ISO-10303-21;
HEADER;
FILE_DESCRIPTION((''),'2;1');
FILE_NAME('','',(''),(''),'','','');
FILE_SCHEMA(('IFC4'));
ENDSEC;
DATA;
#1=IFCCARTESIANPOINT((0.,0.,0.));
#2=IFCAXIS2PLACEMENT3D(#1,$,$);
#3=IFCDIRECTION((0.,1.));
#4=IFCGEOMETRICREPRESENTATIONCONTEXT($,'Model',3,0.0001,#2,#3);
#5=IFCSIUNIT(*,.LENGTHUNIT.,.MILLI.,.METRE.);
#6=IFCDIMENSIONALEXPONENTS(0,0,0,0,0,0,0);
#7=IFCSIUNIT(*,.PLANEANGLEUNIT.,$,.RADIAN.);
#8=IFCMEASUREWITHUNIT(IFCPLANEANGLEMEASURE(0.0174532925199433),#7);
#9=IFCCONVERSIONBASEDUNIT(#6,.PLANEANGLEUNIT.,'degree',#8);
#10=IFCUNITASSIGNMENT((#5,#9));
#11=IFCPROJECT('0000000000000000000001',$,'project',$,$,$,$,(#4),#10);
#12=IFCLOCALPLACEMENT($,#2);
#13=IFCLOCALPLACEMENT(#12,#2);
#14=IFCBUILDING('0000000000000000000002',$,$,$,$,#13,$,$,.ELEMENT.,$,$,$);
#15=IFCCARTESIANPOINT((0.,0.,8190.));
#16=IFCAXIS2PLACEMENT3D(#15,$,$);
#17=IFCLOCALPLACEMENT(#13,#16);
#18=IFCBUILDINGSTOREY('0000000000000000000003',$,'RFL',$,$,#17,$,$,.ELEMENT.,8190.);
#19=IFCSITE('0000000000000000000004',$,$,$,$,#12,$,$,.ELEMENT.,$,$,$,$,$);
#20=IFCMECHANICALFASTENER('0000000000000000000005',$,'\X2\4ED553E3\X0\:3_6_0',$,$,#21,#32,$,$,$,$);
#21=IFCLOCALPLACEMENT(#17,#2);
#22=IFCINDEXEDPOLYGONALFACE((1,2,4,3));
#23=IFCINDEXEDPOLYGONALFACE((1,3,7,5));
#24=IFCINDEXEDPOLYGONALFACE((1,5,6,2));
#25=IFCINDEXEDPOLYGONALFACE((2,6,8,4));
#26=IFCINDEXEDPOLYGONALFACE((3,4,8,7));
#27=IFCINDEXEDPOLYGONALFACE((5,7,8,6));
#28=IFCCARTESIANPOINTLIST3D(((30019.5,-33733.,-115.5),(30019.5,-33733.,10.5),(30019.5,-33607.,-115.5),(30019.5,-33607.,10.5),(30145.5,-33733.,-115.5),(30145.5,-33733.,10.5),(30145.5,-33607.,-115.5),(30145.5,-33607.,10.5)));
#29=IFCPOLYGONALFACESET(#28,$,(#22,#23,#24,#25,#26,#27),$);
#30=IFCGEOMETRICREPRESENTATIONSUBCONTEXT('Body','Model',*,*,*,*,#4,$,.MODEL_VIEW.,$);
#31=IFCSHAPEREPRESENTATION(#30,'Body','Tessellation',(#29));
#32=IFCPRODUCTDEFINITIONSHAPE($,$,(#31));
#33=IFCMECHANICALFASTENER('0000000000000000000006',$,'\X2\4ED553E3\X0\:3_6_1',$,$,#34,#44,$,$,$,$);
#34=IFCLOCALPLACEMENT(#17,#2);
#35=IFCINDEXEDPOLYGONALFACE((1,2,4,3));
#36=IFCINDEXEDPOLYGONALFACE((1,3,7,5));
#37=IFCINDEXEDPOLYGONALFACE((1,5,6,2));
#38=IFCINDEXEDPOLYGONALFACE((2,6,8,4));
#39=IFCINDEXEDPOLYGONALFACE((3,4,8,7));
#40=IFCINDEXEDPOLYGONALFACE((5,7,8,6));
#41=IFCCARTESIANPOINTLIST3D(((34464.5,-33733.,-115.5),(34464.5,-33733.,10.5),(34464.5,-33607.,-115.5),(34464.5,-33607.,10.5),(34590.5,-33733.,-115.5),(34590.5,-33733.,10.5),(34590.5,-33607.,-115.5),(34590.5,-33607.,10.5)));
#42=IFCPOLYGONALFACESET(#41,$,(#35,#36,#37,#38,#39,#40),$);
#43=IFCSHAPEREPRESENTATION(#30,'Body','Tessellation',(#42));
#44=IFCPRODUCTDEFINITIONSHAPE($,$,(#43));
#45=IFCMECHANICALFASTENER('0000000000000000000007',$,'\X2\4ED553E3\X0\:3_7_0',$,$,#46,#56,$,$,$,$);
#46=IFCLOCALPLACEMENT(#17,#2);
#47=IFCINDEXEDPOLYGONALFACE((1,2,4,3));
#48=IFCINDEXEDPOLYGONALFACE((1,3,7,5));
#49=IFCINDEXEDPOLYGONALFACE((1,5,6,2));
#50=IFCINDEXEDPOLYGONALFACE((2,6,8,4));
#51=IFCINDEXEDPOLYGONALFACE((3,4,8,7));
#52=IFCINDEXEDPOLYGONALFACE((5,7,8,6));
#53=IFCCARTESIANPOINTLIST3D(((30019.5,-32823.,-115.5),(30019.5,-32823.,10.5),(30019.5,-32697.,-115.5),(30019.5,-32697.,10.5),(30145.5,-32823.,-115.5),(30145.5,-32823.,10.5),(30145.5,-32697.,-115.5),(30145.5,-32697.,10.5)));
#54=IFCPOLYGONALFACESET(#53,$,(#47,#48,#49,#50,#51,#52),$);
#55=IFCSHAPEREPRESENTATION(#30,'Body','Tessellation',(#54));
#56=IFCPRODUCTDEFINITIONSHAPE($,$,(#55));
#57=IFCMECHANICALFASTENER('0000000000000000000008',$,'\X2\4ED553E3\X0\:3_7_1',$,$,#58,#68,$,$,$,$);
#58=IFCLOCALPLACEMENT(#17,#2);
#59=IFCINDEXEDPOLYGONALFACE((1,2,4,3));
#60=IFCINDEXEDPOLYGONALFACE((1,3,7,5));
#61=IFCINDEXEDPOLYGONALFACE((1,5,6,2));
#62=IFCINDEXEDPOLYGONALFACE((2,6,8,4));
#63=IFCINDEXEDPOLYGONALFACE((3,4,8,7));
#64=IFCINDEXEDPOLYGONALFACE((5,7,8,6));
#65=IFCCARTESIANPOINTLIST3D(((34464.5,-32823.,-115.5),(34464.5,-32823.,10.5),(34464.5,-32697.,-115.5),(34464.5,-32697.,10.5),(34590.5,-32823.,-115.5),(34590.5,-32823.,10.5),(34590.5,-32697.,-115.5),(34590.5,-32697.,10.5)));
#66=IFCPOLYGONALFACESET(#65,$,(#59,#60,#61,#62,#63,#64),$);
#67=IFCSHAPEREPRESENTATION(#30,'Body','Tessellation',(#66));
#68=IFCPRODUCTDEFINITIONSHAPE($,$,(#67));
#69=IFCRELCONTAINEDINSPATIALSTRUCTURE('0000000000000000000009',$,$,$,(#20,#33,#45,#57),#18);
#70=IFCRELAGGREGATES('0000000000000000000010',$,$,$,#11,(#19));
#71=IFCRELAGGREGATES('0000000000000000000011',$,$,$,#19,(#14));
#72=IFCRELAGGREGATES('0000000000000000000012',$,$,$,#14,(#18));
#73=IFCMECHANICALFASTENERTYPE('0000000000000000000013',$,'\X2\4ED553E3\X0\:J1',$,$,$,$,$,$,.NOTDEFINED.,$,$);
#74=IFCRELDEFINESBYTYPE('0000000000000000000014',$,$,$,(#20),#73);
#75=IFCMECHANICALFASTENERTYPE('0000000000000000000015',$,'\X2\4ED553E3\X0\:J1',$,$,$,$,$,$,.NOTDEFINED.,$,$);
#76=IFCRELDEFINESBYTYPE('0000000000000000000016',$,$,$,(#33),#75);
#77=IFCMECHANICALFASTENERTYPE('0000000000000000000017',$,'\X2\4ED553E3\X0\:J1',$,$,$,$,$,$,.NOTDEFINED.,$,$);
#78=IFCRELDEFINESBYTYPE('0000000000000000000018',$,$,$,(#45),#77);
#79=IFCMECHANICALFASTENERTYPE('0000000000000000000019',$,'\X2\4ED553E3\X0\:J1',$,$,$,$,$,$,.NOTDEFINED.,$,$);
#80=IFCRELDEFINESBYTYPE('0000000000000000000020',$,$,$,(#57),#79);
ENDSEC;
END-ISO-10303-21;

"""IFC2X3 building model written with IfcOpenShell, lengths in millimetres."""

from ifc_helpers import new_model, entity, si_unit, converted_unit, direction, frame, origin, origin_with_axes, origin_2d, place, context, subcontext, project, spatial, rectangle, extrude, type_object, element, save


model = new_model("IFC2X3")

# Units and contexts
model_context = context("Model", 3, precision=0.0001, world=origin(), true_north=direction((0.0, 1.0)))
body_context = subcontext(model_context, "Body", "Model", "MODEL_VIEW")
ifc_project = project(units=[si_unit("LENGTHUNIT", "METRE", prefix="MILLI"), converted_unit("PLANEANGLEUNIT", "degree", entity("IfcPlaneAngleMeasure", 0.0174532925199433), si_unit("PLANEANGLEUNIT", "RADIAN"), dimensions=[0, 0, 0, 0, 0, 0, 0])], contexts=[model_context])

# Site, building, storey
site_placement = place(None, origin())
site = spatial("IfcSite", under=ifc_project, at=site_placement, CompositionType="ELEMENT")
building_placement = place(site_placement, origin())
building = spatial("IfcBuilding", under=site, at=building_placement, CompositionType="ELEMENT")
storey_placement = place(building_placement, frame((0.0, 0.0, 8190.0)))
storey = spatial("IfcBuildingStorey", under=building, at=storey_placement, Name="RFL", CompositionType="ELEMENT", Elevation=8190.0)

# Mechanical fasteners
mechanical_fastener_type_1 = type_object("IfcMechanicalFastenerType", Name="仕口:J1")
mechanical_fastener_1_placement = place(storey_placement, frame((30082.5, -33670.0, -115.5)))
element("IfcMechanicalFastener", 1, at=mechanical_fastener_1_placement, inside=storey, type_object=mechanical_fastener_type_1, Name="仕口:3_6_0", context=body_context, shape_type="SweptSolid", body=[
    extrude(rectangle(XDim=126.0, YDim=126.0, at=origin_2d()), origin_with_axes(), (0.0, 0.0, 1.0), 126.0),
])
mechanical_fastener_type_2 = type_object("IfcMechanicalFastenerType", Name="仕口:J1")
mechanical_fastener_2_placement = place(storey_placement, frame((34527.5, -33670.0, -115.5)))
element("IfcMechanicalFastener", 2, at=mechanical_fastener_2_placement, inside=storey, type_object=mechanical_fastener_type_2, Name="仕口:3_6_1", context=body_context, shape_type="SweptSolid", body=[
    extrude(rectangle(XDim=126.0, YDim=126.0, at=origin_2d()), origin_with_axes(), (0.0, 0.0, 1.0), 126.0),
])
mechanical_fastener_type_3 = type_object("IfcMechanicalFastenerType", Name="仕口:J1")
mechanical_fastener_3_placement = place(storey_placement, frame((30082.5, -32760.0, -115.5)))
element("IfcMechanicalFastener", 3, at=mechanical_fastener_3_placement, inside=storey, type_object=mechanical_fastener_type_3, Name="仕口:3_7_0", context=body_context, shape_type="SweptSolid", body=[
    extrude(rectangle(XDim=126.0, YDim=126.0, at=origin_2d()), origin_with_axes(), (0.0, 0.0, 1.0), 126.0),
])
mechanical_fastener_type_4 = type_object("IfcMechanicalFastenerType", Name="仕口:J1")
mechanical_fastener_4_placement = place(storey_placement, frame((34527.5, -32760.0, -115.5)))
element("IfcMechanicalFastener", 4, at=mechanical_fastener_4_placement, inside=storey, type_object=mechanical_fastener_type_4, Name="仕口:3_7_1", context=body_context, shape_type="SweptSolid", body=[
    extrude(rectangle(XDim=126.0, YDim=126.0, at=origin_2d()), origin_with_axes(), (0.0, 0.0, 1.0), 126.0),
])

save(model, "model.ifc")
